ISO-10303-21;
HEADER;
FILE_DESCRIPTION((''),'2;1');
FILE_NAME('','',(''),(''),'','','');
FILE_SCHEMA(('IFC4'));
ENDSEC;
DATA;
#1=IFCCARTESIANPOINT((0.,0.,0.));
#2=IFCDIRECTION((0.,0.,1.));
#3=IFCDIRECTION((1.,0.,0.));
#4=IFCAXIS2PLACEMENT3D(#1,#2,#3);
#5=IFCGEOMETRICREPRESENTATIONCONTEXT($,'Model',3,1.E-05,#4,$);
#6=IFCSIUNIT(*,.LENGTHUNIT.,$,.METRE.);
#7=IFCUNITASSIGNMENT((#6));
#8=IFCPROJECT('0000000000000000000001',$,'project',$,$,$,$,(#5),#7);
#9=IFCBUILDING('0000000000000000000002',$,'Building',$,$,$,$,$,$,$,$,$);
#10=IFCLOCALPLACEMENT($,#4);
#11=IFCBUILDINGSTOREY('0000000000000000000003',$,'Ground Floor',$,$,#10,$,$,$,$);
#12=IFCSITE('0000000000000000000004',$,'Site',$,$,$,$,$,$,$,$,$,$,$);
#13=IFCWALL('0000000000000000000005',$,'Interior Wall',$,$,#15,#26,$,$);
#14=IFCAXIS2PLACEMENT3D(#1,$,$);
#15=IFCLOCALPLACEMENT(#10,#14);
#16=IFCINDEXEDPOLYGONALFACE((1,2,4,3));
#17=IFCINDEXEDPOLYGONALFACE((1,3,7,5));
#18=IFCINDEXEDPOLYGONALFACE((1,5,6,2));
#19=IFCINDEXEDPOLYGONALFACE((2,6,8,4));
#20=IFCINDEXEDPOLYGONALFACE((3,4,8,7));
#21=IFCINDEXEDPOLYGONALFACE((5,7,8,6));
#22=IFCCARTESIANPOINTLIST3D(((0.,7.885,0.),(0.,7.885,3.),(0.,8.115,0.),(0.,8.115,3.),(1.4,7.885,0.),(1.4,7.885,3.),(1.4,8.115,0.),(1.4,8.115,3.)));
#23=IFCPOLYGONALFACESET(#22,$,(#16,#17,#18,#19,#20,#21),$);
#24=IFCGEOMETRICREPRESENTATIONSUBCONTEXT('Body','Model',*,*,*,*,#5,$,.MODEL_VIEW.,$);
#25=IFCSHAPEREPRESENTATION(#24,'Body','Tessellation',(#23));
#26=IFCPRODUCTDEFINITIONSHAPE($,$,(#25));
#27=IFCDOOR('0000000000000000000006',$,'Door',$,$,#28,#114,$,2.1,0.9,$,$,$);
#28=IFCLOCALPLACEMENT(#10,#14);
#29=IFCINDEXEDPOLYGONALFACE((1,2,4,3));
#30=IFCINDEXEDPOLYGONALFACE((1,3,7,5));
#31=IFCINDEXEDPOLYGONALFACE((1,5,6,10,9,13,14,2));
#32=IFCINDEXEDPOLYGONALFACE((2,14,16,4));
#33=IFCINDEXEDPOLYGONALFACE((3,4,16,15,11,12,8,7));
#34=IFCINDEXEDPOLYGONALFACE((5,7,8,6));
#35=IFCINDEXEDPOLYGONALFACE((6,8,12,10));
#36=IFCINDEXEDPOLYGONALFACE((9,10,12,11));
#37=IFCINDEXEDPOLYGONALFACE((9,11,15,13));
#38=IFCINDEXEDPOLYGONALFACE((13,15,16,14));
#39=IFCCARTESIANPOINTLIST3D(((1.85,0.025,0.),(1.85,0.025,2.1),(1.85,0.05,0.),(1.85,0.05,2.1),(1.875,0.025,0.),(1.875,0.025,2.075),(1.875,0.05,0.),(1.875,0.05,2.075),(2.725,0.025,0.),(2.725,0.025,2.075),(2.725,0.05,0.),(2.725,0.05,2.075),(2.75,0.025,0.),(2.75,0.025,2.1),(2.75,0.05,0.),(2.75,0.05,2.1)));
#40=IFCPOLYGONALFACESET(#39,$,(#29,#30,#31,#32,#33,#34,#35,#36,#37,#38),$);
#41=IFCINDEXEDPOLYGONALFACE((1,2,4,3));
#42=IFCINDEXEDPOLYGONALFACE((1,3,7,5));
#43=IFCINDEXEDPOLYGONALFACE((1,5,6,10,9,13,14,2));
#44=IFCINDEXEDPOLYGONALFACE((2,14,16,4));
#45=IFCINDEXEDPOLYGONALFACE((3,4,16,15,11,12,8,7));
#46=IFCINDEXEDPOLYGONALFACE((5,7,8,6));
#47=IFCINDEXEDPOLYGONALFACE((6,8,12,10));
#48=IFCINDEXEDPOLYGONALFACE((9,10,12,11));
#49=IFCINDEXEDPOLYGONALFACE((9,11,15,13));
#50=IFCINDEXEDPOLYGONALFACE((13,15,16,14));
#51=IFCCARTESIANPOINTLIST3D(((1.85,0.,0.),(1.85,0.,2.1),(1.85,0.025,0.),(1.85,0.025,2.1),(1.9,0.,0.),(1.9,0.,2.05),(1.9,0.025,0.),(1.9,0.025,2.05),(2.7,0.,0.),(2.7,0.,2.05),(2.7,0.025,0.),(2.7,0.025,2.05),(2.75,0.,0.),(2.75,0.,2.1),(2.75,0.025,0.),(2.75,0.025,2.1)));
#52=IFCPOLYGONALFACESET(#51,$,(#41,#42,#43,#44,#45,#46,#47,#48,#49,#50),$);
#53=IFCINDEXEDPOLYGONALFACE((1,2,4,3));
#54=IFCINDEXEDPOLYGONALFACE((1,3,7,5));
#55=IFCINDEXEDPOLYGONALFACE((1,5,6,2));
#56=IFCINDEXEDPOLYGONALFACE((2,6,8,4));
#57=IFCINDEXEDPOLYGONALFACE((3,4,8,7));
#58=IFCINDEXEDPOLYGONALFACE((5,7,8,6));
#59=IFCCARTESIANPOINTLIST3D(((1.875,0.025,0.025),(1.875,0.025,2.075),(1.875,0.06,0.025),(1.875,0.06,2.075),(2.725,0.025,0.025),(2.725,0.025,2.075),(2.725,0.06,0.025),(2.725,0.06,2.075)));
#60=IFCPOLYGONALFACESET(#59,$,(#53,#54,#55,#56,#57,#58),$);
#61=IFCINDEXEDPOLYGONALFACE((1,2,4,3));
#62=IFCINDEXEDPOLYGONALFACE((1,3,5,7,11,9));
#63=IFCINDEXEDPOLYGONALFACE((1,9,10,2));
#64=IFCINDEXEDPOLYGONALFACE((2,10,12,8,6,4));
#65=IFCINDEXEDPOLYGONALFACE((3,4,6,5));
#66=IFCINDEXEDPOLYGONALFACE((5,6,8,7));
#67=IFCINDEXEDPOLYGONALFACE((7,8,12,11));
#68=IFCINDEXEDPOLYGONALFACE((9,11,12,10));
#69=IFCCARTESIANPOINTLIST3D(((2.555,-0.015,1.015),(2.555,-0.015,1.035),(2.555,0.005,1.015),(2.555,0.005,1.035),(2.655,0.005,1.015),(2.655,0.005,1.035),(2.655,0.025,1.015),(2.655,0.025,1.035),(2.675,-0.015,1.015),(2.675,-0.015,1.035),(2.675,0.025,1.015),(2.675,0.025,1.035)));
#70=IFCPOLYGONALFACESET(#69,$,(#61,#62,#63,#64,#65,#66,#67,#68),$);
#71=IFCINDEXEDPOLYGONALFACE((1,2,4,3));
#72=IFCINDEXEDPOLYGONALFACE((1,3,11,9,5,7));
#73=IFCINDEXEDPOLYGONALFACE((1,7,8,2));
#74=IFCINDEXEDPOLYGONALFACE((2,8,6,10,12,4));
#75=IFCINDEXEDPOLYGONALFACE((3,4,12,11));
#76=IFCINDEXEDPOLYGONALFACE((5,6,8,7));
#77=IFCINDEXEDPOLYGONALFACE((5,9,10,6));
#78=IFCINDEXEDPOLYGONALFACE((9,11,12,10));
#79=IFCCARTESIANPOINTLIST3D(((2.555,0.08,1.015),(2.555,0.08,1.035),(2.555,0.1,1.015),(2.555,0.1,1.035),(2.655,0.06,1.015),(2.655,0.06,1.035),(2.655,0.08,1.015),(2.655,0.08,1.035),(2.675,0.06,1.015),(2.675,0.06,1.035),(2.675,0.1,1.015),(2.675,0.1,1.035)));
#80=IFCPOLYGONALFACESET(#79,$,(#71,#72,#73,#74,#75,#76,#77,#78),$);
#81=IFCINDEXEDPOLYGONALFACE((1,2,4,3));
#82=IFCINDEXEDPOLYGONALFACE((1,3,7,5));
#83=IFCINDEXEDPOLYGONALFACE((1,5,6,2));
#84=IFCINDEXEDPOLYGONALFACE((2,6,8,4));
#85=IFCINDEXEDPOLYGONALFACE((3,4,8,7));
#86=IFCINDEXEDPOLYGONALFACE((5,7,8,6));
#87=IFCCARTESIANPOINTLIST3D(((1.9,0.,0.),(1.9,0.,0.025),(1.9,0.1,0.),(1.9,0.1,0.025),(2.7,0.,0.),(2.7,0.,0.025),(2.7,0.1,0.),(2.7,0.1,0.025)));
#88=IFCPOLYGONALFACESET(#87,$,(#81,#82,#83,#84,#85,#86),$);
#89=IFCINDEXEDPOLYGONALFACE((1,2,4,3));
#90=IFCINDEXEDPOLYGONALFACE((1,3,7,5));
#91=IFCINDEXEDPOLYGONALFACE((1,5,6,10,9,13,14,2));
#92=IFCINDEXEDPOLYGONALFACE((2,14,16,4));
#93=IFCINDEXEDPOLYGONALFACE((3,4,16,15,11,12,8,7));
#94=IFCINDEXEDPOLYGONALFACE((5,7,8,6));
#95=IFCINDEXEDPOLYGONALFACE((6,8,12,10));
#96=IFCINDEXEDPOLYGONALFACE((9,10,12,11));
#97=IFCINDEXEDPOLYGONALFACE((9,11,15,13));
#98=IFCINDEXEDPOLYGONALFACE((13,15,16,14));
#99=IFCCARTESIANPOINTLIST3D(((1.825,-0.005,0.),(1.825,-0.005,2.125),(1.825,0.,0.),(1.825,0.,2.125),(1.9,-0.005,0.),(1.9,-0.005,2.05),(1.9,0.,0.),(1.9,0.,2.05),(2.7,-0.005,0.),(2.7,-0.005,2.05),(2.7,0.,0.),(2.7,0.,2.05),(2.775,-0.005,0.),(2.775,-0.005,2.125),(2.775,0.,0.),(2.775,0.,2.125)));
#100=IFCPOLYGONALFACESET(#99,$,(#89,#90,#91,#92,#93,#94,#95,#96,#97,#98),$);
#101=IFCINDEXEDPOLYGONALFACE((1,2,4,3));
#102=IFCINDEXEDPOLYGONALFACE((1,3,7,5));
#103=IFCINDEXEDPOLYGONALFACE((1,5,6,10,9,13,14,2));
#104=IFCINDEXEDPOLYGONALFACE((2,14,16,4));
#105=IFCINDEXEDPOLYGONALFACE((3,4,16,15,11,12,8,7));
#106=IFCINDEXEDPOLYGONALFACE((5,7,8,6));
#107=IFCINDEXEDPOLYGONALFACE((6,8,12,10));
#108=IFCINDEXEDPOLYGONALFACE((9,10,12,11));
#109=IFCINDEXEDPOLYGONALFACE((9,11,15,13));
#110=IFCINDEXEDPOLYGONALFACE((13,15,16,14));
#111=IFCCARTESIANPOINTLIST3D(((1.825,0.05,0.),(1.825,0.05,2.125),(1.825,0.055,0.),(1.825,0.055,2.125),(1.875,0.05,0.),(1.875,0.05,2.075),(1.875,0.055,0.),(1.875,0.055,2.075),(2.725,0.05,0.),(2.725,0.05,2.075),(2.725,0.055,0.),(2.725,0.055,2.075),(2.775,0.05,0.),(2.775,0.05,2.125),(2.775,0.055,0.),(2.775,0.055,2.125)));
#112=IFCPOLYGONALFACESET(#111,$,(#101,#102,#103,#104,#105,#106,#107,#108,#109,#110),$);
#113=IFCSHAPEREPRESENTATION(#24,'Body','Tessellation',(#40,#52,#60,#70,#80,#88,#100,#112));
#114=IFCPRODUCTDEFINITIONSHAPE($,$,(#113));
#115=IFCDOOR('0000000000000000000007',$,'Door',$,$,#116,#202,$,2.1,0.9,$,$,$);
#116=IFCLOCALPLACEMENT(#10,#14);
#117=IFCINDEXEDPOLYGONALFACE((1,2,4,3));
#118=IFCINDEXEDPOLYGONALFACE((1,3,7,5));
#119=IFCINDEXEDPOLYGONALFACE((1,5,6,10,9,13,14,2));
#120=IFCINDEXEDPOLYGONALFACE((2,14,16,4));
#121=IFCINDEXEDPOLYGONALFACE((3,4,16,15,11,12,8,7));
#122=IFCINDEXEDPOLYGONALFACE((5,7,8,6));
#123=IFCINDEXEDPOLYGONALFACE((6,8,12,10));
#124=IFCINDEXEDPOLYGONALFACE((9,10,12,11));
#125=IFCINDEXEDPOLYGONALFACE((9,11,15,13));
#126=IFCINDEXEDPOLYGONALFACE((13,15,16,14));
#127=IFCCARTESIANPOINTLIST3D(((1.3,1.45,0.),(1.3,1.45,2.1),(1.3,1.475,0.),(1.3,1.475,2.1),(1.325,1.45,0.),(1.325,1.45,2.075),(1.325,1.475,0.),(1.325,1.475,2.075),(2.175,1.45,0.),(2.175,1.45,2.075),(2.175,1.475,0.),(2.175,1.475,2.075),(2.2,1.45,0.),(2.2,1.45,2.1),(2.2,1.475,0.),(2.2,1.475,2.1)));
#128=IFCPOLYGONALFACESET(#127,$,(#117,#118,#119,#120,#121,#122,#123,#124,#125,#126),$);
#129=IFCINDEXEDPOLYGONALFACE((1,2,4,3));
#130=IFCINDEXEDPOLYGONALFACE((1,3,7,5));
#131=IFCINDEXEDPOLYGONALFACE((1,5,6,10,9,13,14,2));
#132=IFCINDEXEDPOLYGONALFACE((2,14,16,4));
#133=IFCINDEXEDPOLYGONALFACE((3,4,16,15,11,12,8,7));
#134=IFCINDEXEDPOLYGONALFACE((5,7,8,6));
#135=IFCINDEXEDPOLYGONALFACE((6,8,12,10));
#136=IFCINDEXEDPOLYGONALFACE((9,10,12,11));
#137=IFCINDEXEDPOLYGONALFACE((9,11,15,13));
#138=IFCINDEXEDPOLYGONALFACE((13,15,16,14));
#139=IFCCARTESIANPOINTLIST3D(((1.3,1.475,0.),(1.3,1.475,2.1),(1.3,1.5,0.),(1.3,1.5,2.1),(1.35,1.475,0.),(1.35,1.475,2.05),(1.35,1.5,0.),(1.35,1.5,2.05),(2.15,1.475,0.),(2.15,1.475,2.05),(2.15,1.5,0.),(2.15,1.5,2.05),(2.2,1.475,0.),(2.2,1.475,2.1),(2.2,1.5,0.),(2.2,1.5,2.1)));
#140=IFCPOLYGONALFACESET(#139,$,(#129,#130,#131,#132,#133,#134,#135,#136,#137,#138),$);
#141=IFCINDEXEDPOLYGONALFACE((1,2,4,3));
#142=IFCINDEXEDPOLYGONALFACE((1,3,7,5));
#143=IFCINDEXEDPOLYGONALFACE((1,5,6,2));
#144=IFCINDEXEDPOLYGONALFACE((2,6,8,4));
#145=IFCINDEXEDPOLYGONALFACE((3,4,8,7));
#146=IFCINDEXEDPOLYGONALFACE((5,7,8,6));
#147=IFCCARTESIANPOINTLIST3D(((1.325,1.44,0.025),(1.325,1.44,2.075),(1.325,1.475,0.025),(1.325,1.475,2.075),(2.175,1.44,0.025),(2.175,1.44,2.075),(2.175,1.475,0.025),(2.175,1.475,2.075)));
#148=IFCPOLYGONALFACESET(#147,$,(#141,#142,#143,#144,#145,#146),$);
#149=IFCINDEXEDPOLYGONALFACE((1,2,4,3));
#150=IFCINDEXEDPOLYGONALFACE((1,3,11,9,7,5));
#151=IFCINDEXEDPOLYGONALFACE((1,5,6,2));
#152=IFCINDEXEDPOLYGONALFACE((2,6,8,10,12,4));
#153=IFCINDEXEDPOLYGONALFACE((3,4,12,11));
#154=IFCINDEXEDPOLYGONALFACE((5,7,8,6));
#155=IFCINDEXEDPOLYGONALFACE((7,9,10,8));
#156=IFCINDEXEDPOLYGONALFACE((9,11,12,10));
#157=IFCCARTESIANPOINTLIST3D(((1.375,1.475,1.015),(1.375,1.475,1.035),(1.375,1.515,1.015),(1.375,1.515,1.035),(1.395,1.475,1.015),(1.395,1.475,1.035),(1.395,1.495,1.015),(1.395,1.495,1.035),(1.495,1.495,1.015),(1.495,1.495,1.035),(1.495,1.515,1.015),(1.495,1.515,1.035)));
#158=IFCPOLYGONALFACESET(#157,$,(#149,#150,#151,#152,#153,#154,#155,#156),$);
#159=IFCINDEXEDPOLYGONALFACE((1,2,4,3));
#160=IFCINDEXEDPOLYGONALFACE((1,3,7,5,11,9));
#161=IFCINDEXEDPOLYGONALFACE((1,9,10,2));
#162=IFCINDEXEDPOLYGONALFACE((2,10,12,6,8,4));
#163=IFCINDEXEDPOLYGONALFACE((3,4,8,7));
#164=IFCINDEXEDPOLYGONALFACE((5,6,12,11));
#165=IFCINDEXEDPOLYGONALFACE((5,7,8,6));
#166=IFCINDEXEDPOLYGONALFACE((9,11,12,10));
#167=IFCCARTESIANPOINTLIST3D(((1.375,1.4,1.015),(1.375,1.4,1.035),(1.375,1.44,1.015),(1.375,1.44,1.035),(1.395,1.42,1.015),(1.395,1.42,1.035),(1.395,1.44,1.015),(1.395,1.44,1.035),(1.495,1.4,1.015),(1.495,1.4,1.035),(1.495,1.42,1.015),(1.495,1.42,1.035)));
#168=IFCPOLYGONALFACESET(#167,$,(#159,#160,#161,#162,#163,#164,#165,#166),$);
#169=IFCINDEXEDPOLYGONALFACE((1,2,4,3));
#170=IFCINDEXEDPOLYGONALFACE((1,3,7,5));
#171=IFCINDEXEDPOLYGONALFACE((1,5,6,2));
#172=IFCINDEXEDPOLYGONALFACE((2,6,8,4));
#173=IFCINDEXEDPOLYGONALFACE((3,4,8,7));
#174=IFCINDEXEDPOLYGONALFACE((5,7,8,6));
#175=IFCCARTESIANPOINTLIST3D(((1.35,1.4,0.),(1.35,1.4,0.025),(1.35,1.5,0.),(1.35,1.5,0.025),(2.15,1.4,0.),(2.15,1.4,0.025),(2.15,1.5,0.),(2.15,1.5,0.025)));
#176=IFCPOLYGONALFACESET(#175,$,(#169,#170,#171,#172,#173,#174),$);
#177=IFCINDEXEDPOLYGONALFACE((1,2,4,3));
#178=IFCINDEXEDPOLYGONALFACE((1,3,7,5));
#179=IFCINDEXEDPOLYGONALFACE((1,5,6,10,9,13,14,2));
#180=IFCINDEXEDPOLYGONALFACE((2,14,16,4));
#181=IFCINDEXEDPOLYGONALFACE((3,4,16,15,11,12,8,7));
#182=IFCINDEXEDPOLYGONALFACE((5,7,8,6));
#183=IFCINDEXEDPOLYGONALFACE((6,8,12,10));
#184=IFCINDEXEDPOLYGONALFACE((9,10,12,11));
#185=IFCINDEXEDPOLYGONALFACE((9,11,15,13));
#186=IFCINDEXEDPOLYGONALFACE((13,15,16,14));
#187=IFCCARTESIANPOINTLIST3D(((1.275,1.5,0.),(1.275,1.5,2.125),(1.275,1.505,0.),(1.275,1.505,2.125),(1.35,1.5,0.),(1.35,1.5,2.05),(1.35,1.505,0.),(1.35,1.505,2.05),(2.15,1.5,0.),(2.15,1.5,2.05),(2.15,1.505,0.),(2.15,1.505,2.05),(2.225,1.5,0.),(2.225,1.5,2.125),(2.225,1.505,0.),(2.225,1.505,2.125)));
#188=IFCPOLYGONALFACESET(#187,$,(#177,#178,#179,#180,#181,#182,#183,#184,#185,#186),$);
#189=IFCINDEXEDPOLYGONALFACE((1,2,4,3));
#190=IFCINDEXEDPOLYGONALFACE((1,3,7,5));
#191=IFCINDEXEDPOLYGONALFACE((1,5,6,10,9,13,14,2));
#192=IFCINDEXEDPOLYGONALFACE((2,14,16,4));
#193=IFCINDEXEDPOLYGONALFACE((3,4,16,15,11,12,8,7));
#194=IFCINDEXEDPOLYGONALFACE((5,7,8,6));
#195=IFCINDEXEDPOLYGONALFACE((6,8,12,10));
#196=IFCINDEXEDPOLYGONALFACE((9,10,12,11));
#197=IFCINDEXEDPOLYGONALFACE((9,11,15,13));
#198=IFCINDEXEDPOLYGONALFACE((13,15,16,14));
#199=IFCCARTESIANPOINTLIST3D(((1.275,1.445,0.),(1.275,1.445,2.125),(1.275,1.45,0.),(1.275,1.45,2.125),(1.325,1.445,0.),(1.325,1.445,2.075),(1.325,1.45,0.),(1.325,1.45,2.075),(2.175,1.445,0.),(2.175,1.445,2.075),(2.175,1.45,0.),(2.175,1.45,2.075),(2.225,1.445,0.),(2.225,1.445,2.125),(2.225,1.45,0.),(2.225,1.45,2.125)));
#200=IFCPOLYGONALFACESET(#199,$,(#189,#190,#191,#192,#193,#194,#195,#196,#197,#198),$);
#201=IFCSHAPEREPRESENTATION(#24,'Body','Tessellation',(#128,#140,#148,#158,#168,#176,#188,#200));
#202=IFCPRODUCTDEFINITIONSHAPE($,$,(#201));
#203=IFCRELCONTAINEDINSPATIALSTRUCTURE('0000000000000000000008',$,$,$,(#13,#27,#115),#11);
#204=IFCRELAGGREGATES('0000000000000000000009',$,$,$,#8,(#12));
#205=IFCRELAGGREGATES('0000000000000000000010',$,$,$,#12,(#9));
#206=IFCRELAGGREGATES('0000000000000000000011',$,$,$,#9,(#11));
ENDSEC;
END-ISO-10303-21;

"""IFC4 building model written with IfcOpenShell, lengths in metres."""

from ifc_helpers import new_model, si_unit, frame, origin_with_axes, place, context, subcontext, project, spatial, line, indexed_curve, outline, extrude, element, save


model = new_model("IFC4")

# Units and contexts
model_context = context("Model", 3, precision=1e-05, world=origin_with_axes())
body_context = subcontext(model_context, "Body", "Model", "MODEL_VIEW")
ifc_project = project(units=[si_unit("LENGTHUNIT", "METRE")], contexts=[model_context])

# Site, building, storey
site = spatial("IfcSite", under=ifc_project, Name="Site")
building = spatial("IfcBuilding", under=site, Name="Building")
storey_placement = place(None, origin_with_axes())
storey = spatial("IfcBuildingStorey", under=building, at=storey_placement, Name="Ground Floor")

# Wall
for number, where, z_axis, x_axis, name in (
    (1, (1.4, 8.0, 0.0), (0.0, 0.0, 1.0), (-1.0, 0.0, 0.0), "Interior Wall"),
):
    element("IfcWall", number, at=place(storey_placement, frame(where, z_axis=z_axis, x_axis=x_axis)), inside=storey, Name=name, context=body_context, shape_type="SweptSolid", body=[
        extrude(outline(indexed_curve([(0.0, 0.0), (0.0, 0.23), (1.4, 0.23), (1.4, 0.0), (0.0, 0.0)], self_intersect=False)), frame((0.0, -0.115, 0.0), z_axis=(0.0, 0.0, 1.0), x_axis=(1.0, 0.0, 0.0)), (0.0, 0.0, 1.0), 3.0),
    ])

# Doors
door_1_placement = place(storey_placement, frame((1.85, 0.0, 0.0), z_axis=(0.0, 0.0, 1.0), x_axis=(1.0, 0.0, 0.0)))
element("IfcDoor", 2, at=door_1_placement, inside=storey, Name="Door", OverallHeight=2.1, OverallWidth=0.9, context=body_context, shape_type="SweptSolid", body=[
    extrude(outline(indexed_curve([(0.0, 0.0), (0.0, 2.1), (0.9, 2.1), (0.9, 0.0), (0.875, 0.0), (0.875, 2.075), (0.025, 2.075), (0.025, 0.0)], segments=[line(1, 2, 3, 4, 5, 6, 7, 8, 1)])), frame((0.0, 0.025, 0.0), z_axis=(0.0, -1.0, 0.0), x_axis=(1.0, 0.0, 0.0)), (0.0, 0.0, -1.0), 0.025),
    extrude(outline(indexed_curve([(0.0, 0.0), (0.0, 2.1), (0.9, 2.1), (0.9, 0.0), (0.85, 0.0), (0.85, 2.05), (0.05, 2.05), (0.05, 0.0)], segments=[line(1, 2, 3, 4, 5, 6, 7, 8, 1)])), frame((0.0, 0.0, 0.0), z_axis=(0.0, -1.0, 0.0), x_axis=(1.0, 0.0, 0.0)), (0.0, 0.0, -1.0), 0.025),
    extrude(outline(indexed_curve([(0.0, 0.0), (0.85, 0.0), (0.85, 0.035), (0.0, 0.035)], segments=[line(1, 2, 3, 4, 1)])), frame((0.025, 0.025, 0.025), z_axis=(0.0, 0.0, 1.0), x_axis=(1.0, 0.0, 0.0)), (0.0, 0.0, 1.0), 2.05),
    extrude(outline(indexed_curve([(0.0, 0.0), (0.0, -0.04), (-0.12, -0.04), (-0.12, -0.02), (-0.02, -0.02), (-0.02, 0.0)], segments=[line(1, 2, 3, 4, 5, 6, 1)])), frame((0.825, 0.025, 1.015), z_axis=(0.0, 0.0, 1.0), x_axis=(1.0, 0.0, 0.0)), (0.0, 0.0, 1.0), 0.02),
    extrude(outline(indexed_curve([(0.0, 0.0), (0.0, 0.04), (-0.12, 0.04), (-0.12, 0.02), (-0.02, 0.02), (-0.02, 0.0)], segments=[line(1, 2, 3, 4, 5, 6, 1)])), frame((0.825, 0.06, 1.015), z_axis=(0.0, 0.0, 1.0), x_axis=(1.0, 0.0, 0.0)), (0.0, 0.0, 1.0), 0.02),
    extrude(outline(indexed_curve([(0.0, 0.0), (0.8, 0.0), (0.8, 0.1), (0.0, 0.1)], segments=[line(1, 2, 3, 4, 1)])), frame((0.05, 0.0, 0.0), z_axis=(0.0, 0.0, 1.0), x_axis=(1.0, 0.0, 0.0)), (0.0, 0.0, 1.0), 0.025),
    extrude(outline(indexed_curve([(0.0, 0.0), (0.0, 2.125), (0.95, 2.125), (0.95, 0.0), (0.875, 0.0), (0.875, 2.05), (0.075, 2.05), (0.075, 0.0)], segments=[line(1, 2, 3, 4, 5, 6, 7, 8, 1)])), frame((-0.025, -0.005, 0.0), z_axis=(0.0, -1.0, 0.0), x_axis=(1.0, 0.0, 0.0)), (0.0, 0.0, -1.0), 0.005),
    extrude(outline(indexed_curve([(0.0, 0.0), (0.0, 2.125), (0.95, 2.125), (0.95, 0.0), (0.9, 0.0), (0.9, 2.075), (0.05, 2.075), (0.05, 0.0)], segments=[line(1, 2, 3, 4, 5, 6, 7, 8, 1)])), frame((-0.025, 0.05, 0.0), z_axis=(0.0, -1.0, 0.0), x_axis=(1.0, 0.0, 0.0)), (0.0, 0.0, -1.0), 0.005),
])
door_2_placement = place(storey_placement, frame((2.2, 1.5, 0.0), z_axis=(0.0, 0.0, 1.0), x_axis=(-1.0, 0.0, 0.0)))
element("IfcDoor", 3, at=door_2_placement, inside=storey, Name="Door", OverallHeight=2.1, OverallWidth=0.9, context=body_context, shape_type="SweptSolid", body=[
    extrude(outline(indexed_curve([(0.0, 0.0), (0.0, 2.1), (0.9, 2.1), (0.9, 0.0), (0.875, 0.0), (0.875, 2.075), (0.025, 2.075), (0.025, 0.0)], segments=[line(1, 2, 3, 4, 5, 6, 7, 8, 1)])), frame((0.0, 0.025, 0.0), z_axis=(0.0, -1.0, 0.0), x_axis=(1.0, 0.0, 0.0)), (0.0, 0.0, -1.0), 0.025),
    extrude(outline(indexed_curve([(0.0, 0.0), (0.0, 2.1), (0.9, 2.1), (0.9, 0.0), (0.85, 0.0), (0.85, 2.05), (0.05, 2.05), (0.05, 0.0)], segments=[line(1, 2, 3, 4, 5, 6, 7, 8, 1)])), frame((0.0, 0.0, 0.0), z_axis=(0.0, -1.0, 0.0), x_axis=(1.0, 0.0, 0.0)), (0.0, 0.0, -1.0), 0.025),
    extrude(outline(indexed_curve([(0.0, 0.0), (0.85, 0.0), (0.85, 0.035), (0.0, 0.035)], segments=[line(1, 2, 3, 4, 1)])), frame((0.025, 0.025, 0.025), z_axis=(0.0, 0.0, 1.0), x_axis=(1.0, 0.0, 0.0)), (0.0, 0.0, 1.0), 2.05),
    extrude(outline(indexed_curve([(0.0, 0.0), (0.0, -0.04), (-0.12, -0.04), (-0.12, -0.02), (-0.02, -0.02), (-0.02, 0.0)], segments=[line(1, 2, 3, 4, 5, 6, 1)])), frame((0.825, 0.025, 1.015), z_axis=(0.0, 0.0, 1.0), x_axis=(1.0, 0.0, 0.0)), (0.0, 0.0, 1.0), 0.02),
    extrude(outline(indexed_curve([(0.0, 0.0), (0.0, 0.04), (-0.12, 0.04), (-0.12, 0.02), (-0.02, 0.02), (-0.02, 0.0)], segments=[line(1, 2, 3, 4, 5, 6, 1)])), frame((0.825, 0.06, 1.015), z_axis=(0.0, 0.0, 1.0), x_axis=(1.0, 0.0, 0.0)), (0.0, 0.0, 1.0), 0.02),
    extrude(outline(indexed_curve([(0.0, 0.0), (0.8, 0.0), (0.8, 0.1), (0.0, 0.1)], segments=[line(1, 2, 3, 4, 1)])), frame((0.05, 0.0, 0.0), z_axis=(0.0, 0.0, 1.0), x_axis=(1.0, 0.0, 0.0)), (0.0, 0.0, 1.0), 0.025),
    extrude(outline(indexed_curve([(0.0, 0.0), (0.0, 2.125), (0.95, 2.125), (0.95, 0.0), (0.875, 0.0), (0.875, 2.05), (0.075, 2.05), (0.075, 0.0)], segments=[line(1, 2, 3, 4, 5, 6, 7, 8, 1)])), frame((-0.025, -0.005, 0.0), z_axis=(0.0, -1.0, 0.0), x_axis=(1.0, 0.0, 0.0)), (0.0, 0.0, -1.0), 0.005),
    extrude(outline(indexed_curve([(0.0, 0.0), (0.0, 2.125), (0.95, 2.125), (0.95, 0.0), (0.9, 0.0), (0.9, 2.075), (0.05, 2.075), (0.05, 0.0)], segments=[line(1, 2, 3, 4, 5, 6, 7, 8, 1)])), frame((-0.025, 0.05, 0.0), z_axis=(0.0, -1.0, 0.0), x_axis=(1.0, 0.0, 0.0)), (0.0, 0.0, -1.0), 0.005),
])

save(model, "model.ifc")
